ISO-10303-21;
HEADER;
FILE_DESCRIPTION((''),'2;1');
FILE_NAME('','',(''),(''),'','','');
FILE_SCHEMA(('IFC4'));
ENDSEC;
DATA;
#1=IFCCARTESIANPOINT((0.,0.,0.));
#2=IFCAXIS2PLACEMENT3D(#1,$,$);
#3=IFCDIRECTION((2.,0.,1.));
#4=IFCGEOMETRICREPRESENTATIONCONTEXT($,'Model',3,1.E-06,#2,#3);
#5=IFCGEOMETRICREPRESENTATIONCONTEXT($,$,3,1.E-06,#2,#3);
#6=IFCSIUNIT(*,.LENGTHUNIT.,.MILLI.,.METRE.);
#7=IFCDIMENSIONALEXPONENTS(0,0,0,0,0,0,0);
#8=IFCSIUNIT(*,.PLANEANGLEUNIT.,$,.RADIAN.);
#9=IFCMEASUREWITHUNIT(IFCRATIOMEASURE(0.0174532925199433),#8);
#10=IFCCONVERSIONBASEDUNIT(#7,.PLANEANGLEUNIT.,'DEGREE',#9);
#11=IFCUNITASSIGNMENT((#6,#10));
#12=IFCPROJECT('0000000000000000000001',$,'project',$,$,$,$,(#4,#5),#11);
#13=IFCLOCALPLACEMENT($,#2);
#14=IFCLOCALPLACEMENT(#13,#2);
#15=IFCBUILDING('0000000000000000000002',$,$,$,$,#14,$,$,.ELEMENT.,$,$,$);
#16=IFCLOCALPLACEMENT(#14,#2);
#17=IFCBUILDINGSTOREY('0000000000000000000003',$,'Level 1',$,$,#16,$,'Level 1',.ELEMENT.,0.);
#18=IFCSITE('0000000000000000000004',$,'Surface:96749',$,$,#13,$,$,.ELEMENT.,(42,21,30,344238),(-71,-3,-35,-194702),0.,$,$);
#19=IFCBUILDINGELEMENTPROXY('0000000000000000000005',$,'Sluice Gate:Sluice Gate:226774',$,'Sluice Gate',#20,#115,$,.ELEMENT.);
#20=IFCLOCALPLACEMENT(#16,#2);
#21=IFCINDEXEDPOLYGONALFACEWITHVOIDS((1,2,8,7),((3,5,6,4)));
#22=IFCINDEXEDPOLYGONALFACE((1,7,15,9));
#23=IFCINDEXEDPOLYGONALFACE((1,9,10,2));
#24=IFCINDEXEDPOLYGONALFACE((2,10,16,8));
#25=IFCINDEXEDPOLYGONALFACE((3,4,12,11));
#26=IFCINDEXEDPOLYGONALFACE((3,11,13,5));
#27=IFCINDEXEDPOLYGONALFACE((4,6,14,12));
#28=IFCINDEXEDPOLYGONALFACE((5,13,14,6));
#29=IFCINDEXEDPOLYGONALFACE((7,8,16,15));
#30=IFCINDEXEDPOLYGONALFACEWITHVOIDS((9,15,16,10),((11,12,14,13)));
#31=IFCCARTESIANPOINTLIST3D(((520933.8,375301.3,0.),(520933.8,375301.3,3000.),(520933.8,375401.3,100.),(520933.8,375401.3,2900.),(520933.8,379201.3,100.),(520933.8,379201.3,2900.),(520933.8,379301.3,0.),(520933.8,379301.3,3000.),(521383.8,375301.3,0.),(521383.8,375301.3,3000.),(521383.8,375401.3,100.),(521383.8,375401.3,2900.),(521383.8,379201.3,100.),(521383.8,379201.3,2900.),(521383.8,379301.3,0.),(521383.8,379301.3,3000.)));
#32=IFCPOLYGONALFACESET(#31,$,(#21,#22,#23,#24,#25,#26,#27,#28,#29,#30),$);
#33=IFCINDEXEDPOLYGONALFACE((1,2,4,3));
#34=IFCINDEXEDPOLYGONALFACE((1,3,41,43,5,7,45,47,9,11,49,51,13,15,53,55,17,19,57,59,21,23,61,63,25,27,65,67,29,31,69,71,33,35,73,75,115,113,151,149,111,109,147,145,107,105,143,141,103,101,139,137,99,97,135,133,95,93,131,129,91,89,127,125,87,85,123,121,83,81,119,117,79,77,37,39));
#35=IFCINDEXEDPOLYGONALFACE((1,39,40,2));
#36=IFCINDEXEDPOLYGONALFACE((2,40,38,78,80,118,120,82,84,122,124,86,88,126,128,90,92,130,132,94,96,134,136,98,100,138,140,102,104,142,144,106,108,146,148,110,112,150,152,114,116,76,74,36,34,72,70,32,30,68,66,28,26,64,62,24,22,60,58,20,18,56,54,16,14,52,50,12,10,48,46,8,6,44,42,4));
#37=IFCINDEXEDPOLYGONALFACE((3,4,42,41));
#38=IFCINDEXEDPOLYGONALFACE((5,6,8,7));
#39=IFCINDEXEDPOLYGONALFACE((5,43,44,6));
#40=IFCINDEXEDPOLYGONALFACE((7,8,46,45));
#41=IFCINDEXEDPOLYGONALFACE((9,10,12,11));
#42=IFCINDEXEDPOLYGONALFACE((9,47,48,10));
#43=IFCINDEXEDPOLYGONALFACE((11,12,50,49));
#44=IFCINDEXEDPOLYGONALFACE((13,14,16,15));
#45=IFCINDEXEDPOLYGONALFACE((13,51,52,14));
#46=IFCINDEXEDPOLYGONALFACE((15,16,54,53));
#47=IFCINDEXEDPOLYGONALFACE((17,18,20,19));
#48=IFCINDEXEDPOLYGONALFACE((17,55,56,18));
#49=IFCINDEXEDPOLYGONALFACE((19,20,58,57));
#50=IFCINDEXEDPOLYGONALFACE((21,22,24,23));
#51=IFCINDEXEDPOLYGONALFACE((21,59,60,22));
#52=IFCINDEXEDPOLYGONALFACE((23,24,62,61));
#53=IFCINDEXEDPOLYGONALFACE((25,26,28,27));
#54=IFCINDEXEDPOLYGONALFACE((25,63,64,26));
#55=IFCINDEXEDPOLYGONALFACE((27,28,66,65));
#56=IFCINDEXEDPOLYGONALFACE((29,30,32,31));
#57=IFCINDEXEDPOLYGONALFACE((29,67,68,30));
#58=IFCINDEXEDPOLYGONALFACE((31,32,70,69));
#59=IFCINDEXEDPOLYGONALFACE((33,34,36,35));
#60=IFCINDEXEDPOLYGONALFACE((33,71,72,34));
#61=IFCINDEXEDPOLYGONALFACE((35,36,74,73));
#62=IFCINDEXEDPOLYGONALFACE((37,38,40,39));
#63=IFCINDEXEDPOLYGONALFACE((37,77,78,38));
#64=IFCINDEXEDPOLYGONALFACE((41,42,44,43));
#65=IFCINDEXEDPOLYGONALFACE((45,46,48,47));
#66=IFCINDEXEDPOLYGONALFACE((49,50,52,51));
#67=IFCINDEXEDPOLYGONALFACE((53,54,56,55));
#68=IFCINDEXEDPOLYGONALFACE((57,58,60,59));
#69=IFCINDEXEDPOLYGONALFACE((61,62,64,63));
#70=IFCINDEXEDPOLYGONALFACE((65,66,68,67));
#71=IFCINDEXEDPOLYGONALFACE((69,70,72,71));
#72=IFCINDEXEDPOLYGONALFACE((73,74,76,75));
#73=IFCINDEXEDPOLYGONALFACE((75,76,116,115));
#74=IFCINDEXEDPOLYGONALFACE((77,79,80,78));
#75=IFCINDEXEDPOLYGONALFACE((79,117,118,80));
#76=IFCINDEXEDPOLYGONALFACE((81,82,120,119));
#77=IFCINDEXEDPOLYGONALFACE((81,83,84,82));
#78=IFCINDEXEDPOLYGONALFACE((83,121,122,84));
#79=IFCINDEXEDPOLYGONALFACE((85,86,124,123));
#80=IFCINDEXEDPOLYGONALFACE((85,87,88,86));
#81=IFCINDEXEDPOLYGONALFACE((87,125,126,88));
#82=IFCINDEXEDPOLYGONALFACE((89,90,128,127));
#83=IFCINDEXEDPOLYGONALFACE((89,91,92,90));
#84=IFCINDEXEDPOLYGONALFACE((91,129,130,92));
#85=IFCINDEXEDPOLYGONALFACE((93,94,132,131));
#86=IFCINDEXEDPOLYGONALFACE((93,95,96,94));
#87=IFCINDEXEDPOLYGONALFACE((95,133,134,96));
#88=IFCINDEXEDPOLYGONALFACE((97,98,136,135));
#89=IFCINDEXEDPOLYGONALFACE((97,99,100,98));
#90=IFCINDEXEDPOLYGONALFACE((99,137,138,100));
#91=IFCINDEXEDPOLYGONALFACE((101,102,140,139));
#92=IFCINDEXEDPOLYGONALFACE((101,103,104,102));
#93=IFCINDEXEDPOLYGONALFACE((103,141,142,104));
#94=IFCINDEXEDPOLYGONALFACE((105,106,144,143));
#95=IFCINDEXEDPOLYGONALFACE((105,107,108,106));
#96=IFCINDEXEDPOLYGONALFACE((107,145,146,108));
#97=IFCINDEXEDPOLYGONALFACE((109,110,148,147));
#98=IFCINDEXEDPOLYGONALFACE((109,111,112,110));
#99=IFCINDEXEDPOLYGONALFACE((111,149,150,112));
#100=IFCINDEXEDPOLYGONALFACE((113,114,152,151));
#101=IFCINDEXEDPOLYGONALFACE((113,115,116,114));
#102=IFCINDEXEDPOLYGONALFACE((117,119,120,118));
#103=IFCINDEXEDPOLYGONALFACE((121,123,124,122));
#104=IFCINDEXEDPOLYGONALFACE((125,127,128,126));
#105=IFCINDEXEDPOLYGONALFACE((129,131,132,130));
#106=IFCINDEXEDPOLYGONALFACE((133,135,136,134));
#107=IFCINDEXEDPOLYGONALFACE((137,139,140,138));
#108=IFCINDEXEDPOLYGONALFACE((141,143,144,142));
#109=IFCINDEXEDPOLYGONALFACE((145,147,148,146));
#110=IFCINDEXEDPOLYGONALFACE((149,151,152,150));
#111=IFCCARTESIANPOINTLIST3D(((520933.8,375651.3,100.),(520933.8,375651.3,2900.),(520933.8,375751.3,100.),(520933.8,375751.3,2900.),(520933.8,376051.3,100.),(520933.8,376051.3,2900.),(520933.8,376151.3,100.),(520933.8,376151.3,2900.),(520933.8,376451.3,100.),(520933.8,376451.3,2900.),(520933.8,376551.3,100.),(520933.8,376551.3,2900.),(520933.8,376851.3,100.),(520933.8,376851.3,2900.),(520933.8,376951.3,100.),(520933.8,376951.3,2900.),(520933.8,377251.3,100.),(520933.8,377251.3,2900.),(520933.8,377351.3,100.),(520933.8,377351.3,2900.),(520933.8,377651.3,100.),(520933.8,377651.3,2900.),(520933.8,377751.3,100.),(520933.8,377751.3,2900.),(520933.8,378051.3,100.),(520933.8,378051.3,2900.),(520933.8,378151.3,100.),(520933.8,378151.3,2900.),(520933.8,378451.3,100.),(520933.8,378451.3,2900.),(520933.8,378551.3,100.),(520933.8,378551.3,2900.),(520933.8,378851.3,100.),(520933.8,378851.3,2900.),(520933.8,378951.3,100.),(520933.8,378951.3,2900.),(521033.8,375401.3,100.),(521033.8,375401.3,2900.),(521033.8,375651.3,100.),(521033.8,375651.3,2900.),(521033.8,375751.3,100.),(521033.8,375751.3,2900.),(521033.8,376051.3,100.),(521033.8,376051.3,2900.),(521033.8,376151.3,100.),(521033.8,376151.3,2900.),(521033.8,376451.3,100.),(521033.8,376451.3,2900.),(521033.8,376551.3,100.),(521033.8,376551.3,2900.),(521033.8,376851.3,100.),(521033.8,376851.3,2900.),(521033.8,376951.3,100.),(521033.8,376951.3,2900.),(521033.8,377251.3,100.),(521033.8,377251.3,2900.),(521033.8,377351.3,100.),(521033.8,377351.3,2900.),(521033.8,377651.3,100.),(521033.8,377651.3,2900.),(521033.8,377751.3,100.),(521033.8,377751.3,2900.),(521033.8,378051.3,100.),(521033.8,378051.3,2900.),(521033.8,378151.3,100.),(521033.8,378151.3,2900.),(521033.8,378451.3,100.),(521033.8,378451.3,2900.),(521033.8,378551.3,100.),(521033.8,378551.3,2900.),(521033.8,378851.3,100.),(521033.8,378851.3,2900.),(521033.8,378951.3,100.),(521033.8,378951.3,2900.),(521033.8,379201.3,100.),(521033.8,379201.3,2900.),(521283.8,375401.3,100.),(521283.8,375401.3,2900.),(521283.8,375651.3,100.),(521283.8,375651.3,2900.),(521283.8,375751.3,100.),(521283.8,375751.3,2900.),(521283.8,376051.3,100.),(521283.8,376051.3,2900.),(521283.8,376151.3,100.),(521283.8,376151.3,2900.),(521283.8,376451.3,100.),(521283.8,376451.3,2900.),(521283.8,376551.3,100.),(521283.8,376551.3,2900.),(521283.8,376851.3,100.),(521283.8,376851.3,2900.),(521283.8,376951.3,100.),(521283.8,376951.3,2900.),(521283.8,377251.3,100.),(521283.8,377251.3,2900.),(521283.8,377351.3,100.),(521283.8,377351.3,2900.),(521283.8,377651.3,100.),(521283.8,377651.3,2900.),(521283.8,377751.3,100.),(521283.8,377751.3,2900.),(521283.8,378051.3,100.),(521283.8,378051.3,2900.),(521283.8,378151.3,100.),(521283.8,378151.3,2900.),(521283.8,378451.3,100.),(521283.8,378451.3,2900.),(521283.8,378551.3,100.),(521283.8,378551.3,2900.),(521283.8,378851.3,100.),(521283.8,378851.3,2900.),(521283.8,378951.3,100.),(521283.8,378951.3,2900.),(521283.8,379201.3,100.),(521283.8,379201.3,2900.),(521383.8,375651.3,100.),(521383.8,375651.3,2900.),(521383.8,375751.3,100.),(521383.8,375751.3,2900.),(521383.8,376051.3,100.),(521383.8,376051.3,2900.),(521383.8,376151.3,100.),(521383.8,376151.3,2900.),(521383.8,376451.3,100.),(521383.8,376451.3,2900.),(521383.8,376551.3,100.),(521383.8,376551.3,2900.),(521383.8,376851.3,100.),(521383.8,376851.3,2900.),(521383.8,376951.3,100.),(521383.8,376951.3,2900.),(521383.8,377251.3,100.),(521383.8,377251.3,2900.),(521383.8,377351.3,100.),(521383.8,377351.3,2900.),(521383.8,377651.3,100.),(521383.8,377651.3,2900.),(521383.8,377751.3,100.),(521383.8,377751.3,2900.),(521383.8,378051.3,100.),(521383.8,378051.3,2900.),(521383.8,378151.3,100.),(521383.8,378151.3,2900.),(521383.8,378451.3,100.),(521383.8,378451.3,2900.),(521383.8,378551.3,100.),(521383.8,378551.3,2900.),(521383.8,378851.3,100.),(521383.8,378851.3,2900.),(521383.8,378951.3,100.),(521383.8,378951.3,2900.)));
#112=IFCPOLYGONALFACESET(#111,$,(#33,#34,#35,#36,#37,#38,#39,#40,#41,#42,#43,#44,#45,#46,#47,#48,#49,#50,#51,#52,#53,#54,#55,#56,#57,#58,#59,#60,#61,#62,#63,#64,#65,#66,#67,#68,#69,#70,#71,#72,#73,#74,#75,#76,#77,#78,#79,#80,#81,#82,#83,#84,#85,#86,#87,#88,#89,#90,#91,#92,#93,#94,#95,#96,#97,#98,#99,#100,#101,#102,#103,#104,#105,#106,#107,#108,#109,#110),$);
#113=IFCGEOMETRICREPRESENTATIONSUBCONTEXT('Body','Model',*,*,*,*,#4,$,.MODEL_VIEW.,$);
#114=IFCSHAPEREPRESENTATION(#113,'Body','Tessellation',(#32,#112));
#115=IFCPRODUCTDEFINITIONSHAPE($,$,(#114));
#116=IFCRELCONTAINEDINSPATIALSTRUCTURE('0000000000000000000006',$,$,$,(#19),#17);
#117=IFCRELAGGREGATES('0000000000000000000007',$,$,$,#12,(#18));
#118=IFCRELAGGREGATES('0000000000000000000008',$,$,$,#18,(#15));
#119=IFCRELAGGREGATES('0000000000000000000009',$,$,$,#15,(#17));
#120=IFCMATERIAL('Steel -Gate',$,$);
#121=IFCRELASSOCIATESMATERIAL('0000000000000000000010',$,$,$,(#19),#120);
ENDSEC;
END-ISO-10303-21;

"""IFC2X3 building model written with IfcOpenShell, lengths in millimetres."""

from ifc_helpers import new_model, entity, si_unit, converted_unit, direction, frame, origin, place, context, subcontext, project, spatial, polyline, outline, extrude, source, transform, mapped, material, element, save


model = new_model("IFC2X3")

# Units and contexts
model_context = context("Model", 3, precision=1e-06, world=origin(), true_north=direction((2.0, 0.0, 1.0)))
context_of_model = context(None, 3, precision=1e-06, world=origin(), true_north=direction((2.0, 0.0, 1.0)))
body_context = subcontext(model_context, "Body", "Model", "MODEL_VIEW")
ifc_project = project(units=[si_unit("LENGTHUNIT", "METRE", prefix="MILLI"), converted_unit("PLANEANGLEUNIT", "DEGREE", entity("IfcRatioMeasure", 0.0174532925199433), si_unit("PLANEANGLEUNIT", "RADIAN"), dimensions=[0, 0, 0, 0, 0, 0, 0])], contexts=[model_context, context_of_model])

# Site, building, storey
site_placement = place(None, origin())
site = spatial("IfcSite", under=ifc_project, at=site_placement, Name="Surface:96749", CompositionType="ELEMENT", RefLatitude=(42, 21, 30, 344238), RefLongitude=(-71, -3, -35, -194702), RefElevation=0.0)
building_placement = place(site_placement, origin())
building = spatial("IfcBuilding", under=site, at=building_placement, CompositionType="ELEMENT")
storey_placement = place(building_placement, origin())
storey = spatial("IfcBuildingStorey", under=building, at=storey_placement, Name="Level 1", LongName="Level 1", CompositionType="ELEMENT", Elevation=0.0)

# Building element proxy
ifc_material = material(Name="Steel -Gate")
shared_shape_1 = source(origin(), body_context, "Body", "SweptSolid", [
    extrude(outline(polyline([(-1500.0, -2000.0), (1500.0, -2000.0), (1500.0, 2000.0), (-1500.0, 2000.0), (-1500.0, -2000.0)]), holes=[polyline([(1400.0, -1900.0), (-1400.0, -1900.0), (-1400.0, 1900.0), (1400.0, 1900.0), (1400.0, -1900.0)])]), frame((0.0, -225.0, 1500.0), z_axis=(0.0, 1.0, 0.0), x_axis=(0.0, 0.0, -1.0)), (0.0, 0.0, 1.0), 450.0),
    extrude(outline(polyline([(1650.0, -125.0), (1900.0, -125.0), (1900.0, 125.0), (1650.0, 125.0), (1650.0, 225.0), (1550.0, 225.0), (1550.0, 125.0), (1250.0, 125.0), (1250.0, 225.0), (1150.0, 225.0), (1150.0, 125.0), (850.0, 125.0), (850.0, 225.0), (750.0, 225.0), (750.0, 125.0), (450.0, 125.0), (450.0, 225.0), (350.0, 225.0), (350.0, 125.0), (50.0, 125.0), (50.0, 225.0), (-50.0, 225.0), (-50.0, 125.0), (-350.0, 125.0), (-350.0, 225.0), (-450.0, 225.0), (-450.0, 125.0), (-750.0, 125.0), (-750.0, 225.0), (-850.0, 225.0), (-850.0, 125.0), (-1150.0, 125.0), (-1150.0, 225.0), (-1250.0, 225.0), (-1250.0, 125.0), (-1550.0, 125.0), (-1550.0, 225.0), (-1650.0, 225.0), (-1650.0, 125.0), (-1900.0, 125.0), (-1900.0, -125.0), (-1650.0, -125.0), (-1650.0, -225.0), (-1550.0, -225.0), (-1550.0, -125.0), (-1250.0, -125.0), (-1250.0, -225.0), (-1150.0, -225.0), (-1150.0, -125.0), (-850.0, -125.0), (-850.0, -225.0), (-750.0, -225.0), (-750.0, -125.0), (-450.0, -125.0), (-450.0, -225.0), (-350.0, -225.0), (-350.0, -125.0), (-50.0, -125.0), (-50.0, -225.0), (50.0, -225.0), (50.0, -125.0), (350.0, -125.0), (350.0, -225.0), (450.0, -225.0), (450.0, -125.0), (750.0, -125.0), (750.0, -225.0), (850.0, -225.0), (850.0, -125.0), (1150.0, -125.0), (1150.0, -225.0), (1250.0, -225.0), (1250.0, -125.0), (1550.0, -125.0), (1550.0, -225.0), (1650.0, -225.0), (1650.0, -125.0)])), frame((0.0, 0.0, 100.0), z_axis=(0.0, 0.0, 1.0), x_axis=(-1.0, 0.0, 0.0)), (0.0, 0.0, 1.0), 2800.0),
])
for number, where, z_axis, x_axis, name in (
    (1, (521158.8, 377301.3, 0.0), (0.0, 0.0, 1.0), (0.0, 1.0, 0.0), "Sluice Gate:Sluice Gate:226774"),
):
    element("IfcBuildingElementProxy", number, at=place(storey_placement, frame(where, z_axis=z_axis, x_axis=x_axis)), inside=storey, material=ifc_material, Name=name, ObjectType="Sluice Gate", CompositionType="ELEMENT", context=body_context, shape_type="MappedRepresentation", body=[
        mapped(shared_shape_1, transform((0.0, 0.0, 0.0), scale=1.0)),
    ])

save(model, "model.ifc")
